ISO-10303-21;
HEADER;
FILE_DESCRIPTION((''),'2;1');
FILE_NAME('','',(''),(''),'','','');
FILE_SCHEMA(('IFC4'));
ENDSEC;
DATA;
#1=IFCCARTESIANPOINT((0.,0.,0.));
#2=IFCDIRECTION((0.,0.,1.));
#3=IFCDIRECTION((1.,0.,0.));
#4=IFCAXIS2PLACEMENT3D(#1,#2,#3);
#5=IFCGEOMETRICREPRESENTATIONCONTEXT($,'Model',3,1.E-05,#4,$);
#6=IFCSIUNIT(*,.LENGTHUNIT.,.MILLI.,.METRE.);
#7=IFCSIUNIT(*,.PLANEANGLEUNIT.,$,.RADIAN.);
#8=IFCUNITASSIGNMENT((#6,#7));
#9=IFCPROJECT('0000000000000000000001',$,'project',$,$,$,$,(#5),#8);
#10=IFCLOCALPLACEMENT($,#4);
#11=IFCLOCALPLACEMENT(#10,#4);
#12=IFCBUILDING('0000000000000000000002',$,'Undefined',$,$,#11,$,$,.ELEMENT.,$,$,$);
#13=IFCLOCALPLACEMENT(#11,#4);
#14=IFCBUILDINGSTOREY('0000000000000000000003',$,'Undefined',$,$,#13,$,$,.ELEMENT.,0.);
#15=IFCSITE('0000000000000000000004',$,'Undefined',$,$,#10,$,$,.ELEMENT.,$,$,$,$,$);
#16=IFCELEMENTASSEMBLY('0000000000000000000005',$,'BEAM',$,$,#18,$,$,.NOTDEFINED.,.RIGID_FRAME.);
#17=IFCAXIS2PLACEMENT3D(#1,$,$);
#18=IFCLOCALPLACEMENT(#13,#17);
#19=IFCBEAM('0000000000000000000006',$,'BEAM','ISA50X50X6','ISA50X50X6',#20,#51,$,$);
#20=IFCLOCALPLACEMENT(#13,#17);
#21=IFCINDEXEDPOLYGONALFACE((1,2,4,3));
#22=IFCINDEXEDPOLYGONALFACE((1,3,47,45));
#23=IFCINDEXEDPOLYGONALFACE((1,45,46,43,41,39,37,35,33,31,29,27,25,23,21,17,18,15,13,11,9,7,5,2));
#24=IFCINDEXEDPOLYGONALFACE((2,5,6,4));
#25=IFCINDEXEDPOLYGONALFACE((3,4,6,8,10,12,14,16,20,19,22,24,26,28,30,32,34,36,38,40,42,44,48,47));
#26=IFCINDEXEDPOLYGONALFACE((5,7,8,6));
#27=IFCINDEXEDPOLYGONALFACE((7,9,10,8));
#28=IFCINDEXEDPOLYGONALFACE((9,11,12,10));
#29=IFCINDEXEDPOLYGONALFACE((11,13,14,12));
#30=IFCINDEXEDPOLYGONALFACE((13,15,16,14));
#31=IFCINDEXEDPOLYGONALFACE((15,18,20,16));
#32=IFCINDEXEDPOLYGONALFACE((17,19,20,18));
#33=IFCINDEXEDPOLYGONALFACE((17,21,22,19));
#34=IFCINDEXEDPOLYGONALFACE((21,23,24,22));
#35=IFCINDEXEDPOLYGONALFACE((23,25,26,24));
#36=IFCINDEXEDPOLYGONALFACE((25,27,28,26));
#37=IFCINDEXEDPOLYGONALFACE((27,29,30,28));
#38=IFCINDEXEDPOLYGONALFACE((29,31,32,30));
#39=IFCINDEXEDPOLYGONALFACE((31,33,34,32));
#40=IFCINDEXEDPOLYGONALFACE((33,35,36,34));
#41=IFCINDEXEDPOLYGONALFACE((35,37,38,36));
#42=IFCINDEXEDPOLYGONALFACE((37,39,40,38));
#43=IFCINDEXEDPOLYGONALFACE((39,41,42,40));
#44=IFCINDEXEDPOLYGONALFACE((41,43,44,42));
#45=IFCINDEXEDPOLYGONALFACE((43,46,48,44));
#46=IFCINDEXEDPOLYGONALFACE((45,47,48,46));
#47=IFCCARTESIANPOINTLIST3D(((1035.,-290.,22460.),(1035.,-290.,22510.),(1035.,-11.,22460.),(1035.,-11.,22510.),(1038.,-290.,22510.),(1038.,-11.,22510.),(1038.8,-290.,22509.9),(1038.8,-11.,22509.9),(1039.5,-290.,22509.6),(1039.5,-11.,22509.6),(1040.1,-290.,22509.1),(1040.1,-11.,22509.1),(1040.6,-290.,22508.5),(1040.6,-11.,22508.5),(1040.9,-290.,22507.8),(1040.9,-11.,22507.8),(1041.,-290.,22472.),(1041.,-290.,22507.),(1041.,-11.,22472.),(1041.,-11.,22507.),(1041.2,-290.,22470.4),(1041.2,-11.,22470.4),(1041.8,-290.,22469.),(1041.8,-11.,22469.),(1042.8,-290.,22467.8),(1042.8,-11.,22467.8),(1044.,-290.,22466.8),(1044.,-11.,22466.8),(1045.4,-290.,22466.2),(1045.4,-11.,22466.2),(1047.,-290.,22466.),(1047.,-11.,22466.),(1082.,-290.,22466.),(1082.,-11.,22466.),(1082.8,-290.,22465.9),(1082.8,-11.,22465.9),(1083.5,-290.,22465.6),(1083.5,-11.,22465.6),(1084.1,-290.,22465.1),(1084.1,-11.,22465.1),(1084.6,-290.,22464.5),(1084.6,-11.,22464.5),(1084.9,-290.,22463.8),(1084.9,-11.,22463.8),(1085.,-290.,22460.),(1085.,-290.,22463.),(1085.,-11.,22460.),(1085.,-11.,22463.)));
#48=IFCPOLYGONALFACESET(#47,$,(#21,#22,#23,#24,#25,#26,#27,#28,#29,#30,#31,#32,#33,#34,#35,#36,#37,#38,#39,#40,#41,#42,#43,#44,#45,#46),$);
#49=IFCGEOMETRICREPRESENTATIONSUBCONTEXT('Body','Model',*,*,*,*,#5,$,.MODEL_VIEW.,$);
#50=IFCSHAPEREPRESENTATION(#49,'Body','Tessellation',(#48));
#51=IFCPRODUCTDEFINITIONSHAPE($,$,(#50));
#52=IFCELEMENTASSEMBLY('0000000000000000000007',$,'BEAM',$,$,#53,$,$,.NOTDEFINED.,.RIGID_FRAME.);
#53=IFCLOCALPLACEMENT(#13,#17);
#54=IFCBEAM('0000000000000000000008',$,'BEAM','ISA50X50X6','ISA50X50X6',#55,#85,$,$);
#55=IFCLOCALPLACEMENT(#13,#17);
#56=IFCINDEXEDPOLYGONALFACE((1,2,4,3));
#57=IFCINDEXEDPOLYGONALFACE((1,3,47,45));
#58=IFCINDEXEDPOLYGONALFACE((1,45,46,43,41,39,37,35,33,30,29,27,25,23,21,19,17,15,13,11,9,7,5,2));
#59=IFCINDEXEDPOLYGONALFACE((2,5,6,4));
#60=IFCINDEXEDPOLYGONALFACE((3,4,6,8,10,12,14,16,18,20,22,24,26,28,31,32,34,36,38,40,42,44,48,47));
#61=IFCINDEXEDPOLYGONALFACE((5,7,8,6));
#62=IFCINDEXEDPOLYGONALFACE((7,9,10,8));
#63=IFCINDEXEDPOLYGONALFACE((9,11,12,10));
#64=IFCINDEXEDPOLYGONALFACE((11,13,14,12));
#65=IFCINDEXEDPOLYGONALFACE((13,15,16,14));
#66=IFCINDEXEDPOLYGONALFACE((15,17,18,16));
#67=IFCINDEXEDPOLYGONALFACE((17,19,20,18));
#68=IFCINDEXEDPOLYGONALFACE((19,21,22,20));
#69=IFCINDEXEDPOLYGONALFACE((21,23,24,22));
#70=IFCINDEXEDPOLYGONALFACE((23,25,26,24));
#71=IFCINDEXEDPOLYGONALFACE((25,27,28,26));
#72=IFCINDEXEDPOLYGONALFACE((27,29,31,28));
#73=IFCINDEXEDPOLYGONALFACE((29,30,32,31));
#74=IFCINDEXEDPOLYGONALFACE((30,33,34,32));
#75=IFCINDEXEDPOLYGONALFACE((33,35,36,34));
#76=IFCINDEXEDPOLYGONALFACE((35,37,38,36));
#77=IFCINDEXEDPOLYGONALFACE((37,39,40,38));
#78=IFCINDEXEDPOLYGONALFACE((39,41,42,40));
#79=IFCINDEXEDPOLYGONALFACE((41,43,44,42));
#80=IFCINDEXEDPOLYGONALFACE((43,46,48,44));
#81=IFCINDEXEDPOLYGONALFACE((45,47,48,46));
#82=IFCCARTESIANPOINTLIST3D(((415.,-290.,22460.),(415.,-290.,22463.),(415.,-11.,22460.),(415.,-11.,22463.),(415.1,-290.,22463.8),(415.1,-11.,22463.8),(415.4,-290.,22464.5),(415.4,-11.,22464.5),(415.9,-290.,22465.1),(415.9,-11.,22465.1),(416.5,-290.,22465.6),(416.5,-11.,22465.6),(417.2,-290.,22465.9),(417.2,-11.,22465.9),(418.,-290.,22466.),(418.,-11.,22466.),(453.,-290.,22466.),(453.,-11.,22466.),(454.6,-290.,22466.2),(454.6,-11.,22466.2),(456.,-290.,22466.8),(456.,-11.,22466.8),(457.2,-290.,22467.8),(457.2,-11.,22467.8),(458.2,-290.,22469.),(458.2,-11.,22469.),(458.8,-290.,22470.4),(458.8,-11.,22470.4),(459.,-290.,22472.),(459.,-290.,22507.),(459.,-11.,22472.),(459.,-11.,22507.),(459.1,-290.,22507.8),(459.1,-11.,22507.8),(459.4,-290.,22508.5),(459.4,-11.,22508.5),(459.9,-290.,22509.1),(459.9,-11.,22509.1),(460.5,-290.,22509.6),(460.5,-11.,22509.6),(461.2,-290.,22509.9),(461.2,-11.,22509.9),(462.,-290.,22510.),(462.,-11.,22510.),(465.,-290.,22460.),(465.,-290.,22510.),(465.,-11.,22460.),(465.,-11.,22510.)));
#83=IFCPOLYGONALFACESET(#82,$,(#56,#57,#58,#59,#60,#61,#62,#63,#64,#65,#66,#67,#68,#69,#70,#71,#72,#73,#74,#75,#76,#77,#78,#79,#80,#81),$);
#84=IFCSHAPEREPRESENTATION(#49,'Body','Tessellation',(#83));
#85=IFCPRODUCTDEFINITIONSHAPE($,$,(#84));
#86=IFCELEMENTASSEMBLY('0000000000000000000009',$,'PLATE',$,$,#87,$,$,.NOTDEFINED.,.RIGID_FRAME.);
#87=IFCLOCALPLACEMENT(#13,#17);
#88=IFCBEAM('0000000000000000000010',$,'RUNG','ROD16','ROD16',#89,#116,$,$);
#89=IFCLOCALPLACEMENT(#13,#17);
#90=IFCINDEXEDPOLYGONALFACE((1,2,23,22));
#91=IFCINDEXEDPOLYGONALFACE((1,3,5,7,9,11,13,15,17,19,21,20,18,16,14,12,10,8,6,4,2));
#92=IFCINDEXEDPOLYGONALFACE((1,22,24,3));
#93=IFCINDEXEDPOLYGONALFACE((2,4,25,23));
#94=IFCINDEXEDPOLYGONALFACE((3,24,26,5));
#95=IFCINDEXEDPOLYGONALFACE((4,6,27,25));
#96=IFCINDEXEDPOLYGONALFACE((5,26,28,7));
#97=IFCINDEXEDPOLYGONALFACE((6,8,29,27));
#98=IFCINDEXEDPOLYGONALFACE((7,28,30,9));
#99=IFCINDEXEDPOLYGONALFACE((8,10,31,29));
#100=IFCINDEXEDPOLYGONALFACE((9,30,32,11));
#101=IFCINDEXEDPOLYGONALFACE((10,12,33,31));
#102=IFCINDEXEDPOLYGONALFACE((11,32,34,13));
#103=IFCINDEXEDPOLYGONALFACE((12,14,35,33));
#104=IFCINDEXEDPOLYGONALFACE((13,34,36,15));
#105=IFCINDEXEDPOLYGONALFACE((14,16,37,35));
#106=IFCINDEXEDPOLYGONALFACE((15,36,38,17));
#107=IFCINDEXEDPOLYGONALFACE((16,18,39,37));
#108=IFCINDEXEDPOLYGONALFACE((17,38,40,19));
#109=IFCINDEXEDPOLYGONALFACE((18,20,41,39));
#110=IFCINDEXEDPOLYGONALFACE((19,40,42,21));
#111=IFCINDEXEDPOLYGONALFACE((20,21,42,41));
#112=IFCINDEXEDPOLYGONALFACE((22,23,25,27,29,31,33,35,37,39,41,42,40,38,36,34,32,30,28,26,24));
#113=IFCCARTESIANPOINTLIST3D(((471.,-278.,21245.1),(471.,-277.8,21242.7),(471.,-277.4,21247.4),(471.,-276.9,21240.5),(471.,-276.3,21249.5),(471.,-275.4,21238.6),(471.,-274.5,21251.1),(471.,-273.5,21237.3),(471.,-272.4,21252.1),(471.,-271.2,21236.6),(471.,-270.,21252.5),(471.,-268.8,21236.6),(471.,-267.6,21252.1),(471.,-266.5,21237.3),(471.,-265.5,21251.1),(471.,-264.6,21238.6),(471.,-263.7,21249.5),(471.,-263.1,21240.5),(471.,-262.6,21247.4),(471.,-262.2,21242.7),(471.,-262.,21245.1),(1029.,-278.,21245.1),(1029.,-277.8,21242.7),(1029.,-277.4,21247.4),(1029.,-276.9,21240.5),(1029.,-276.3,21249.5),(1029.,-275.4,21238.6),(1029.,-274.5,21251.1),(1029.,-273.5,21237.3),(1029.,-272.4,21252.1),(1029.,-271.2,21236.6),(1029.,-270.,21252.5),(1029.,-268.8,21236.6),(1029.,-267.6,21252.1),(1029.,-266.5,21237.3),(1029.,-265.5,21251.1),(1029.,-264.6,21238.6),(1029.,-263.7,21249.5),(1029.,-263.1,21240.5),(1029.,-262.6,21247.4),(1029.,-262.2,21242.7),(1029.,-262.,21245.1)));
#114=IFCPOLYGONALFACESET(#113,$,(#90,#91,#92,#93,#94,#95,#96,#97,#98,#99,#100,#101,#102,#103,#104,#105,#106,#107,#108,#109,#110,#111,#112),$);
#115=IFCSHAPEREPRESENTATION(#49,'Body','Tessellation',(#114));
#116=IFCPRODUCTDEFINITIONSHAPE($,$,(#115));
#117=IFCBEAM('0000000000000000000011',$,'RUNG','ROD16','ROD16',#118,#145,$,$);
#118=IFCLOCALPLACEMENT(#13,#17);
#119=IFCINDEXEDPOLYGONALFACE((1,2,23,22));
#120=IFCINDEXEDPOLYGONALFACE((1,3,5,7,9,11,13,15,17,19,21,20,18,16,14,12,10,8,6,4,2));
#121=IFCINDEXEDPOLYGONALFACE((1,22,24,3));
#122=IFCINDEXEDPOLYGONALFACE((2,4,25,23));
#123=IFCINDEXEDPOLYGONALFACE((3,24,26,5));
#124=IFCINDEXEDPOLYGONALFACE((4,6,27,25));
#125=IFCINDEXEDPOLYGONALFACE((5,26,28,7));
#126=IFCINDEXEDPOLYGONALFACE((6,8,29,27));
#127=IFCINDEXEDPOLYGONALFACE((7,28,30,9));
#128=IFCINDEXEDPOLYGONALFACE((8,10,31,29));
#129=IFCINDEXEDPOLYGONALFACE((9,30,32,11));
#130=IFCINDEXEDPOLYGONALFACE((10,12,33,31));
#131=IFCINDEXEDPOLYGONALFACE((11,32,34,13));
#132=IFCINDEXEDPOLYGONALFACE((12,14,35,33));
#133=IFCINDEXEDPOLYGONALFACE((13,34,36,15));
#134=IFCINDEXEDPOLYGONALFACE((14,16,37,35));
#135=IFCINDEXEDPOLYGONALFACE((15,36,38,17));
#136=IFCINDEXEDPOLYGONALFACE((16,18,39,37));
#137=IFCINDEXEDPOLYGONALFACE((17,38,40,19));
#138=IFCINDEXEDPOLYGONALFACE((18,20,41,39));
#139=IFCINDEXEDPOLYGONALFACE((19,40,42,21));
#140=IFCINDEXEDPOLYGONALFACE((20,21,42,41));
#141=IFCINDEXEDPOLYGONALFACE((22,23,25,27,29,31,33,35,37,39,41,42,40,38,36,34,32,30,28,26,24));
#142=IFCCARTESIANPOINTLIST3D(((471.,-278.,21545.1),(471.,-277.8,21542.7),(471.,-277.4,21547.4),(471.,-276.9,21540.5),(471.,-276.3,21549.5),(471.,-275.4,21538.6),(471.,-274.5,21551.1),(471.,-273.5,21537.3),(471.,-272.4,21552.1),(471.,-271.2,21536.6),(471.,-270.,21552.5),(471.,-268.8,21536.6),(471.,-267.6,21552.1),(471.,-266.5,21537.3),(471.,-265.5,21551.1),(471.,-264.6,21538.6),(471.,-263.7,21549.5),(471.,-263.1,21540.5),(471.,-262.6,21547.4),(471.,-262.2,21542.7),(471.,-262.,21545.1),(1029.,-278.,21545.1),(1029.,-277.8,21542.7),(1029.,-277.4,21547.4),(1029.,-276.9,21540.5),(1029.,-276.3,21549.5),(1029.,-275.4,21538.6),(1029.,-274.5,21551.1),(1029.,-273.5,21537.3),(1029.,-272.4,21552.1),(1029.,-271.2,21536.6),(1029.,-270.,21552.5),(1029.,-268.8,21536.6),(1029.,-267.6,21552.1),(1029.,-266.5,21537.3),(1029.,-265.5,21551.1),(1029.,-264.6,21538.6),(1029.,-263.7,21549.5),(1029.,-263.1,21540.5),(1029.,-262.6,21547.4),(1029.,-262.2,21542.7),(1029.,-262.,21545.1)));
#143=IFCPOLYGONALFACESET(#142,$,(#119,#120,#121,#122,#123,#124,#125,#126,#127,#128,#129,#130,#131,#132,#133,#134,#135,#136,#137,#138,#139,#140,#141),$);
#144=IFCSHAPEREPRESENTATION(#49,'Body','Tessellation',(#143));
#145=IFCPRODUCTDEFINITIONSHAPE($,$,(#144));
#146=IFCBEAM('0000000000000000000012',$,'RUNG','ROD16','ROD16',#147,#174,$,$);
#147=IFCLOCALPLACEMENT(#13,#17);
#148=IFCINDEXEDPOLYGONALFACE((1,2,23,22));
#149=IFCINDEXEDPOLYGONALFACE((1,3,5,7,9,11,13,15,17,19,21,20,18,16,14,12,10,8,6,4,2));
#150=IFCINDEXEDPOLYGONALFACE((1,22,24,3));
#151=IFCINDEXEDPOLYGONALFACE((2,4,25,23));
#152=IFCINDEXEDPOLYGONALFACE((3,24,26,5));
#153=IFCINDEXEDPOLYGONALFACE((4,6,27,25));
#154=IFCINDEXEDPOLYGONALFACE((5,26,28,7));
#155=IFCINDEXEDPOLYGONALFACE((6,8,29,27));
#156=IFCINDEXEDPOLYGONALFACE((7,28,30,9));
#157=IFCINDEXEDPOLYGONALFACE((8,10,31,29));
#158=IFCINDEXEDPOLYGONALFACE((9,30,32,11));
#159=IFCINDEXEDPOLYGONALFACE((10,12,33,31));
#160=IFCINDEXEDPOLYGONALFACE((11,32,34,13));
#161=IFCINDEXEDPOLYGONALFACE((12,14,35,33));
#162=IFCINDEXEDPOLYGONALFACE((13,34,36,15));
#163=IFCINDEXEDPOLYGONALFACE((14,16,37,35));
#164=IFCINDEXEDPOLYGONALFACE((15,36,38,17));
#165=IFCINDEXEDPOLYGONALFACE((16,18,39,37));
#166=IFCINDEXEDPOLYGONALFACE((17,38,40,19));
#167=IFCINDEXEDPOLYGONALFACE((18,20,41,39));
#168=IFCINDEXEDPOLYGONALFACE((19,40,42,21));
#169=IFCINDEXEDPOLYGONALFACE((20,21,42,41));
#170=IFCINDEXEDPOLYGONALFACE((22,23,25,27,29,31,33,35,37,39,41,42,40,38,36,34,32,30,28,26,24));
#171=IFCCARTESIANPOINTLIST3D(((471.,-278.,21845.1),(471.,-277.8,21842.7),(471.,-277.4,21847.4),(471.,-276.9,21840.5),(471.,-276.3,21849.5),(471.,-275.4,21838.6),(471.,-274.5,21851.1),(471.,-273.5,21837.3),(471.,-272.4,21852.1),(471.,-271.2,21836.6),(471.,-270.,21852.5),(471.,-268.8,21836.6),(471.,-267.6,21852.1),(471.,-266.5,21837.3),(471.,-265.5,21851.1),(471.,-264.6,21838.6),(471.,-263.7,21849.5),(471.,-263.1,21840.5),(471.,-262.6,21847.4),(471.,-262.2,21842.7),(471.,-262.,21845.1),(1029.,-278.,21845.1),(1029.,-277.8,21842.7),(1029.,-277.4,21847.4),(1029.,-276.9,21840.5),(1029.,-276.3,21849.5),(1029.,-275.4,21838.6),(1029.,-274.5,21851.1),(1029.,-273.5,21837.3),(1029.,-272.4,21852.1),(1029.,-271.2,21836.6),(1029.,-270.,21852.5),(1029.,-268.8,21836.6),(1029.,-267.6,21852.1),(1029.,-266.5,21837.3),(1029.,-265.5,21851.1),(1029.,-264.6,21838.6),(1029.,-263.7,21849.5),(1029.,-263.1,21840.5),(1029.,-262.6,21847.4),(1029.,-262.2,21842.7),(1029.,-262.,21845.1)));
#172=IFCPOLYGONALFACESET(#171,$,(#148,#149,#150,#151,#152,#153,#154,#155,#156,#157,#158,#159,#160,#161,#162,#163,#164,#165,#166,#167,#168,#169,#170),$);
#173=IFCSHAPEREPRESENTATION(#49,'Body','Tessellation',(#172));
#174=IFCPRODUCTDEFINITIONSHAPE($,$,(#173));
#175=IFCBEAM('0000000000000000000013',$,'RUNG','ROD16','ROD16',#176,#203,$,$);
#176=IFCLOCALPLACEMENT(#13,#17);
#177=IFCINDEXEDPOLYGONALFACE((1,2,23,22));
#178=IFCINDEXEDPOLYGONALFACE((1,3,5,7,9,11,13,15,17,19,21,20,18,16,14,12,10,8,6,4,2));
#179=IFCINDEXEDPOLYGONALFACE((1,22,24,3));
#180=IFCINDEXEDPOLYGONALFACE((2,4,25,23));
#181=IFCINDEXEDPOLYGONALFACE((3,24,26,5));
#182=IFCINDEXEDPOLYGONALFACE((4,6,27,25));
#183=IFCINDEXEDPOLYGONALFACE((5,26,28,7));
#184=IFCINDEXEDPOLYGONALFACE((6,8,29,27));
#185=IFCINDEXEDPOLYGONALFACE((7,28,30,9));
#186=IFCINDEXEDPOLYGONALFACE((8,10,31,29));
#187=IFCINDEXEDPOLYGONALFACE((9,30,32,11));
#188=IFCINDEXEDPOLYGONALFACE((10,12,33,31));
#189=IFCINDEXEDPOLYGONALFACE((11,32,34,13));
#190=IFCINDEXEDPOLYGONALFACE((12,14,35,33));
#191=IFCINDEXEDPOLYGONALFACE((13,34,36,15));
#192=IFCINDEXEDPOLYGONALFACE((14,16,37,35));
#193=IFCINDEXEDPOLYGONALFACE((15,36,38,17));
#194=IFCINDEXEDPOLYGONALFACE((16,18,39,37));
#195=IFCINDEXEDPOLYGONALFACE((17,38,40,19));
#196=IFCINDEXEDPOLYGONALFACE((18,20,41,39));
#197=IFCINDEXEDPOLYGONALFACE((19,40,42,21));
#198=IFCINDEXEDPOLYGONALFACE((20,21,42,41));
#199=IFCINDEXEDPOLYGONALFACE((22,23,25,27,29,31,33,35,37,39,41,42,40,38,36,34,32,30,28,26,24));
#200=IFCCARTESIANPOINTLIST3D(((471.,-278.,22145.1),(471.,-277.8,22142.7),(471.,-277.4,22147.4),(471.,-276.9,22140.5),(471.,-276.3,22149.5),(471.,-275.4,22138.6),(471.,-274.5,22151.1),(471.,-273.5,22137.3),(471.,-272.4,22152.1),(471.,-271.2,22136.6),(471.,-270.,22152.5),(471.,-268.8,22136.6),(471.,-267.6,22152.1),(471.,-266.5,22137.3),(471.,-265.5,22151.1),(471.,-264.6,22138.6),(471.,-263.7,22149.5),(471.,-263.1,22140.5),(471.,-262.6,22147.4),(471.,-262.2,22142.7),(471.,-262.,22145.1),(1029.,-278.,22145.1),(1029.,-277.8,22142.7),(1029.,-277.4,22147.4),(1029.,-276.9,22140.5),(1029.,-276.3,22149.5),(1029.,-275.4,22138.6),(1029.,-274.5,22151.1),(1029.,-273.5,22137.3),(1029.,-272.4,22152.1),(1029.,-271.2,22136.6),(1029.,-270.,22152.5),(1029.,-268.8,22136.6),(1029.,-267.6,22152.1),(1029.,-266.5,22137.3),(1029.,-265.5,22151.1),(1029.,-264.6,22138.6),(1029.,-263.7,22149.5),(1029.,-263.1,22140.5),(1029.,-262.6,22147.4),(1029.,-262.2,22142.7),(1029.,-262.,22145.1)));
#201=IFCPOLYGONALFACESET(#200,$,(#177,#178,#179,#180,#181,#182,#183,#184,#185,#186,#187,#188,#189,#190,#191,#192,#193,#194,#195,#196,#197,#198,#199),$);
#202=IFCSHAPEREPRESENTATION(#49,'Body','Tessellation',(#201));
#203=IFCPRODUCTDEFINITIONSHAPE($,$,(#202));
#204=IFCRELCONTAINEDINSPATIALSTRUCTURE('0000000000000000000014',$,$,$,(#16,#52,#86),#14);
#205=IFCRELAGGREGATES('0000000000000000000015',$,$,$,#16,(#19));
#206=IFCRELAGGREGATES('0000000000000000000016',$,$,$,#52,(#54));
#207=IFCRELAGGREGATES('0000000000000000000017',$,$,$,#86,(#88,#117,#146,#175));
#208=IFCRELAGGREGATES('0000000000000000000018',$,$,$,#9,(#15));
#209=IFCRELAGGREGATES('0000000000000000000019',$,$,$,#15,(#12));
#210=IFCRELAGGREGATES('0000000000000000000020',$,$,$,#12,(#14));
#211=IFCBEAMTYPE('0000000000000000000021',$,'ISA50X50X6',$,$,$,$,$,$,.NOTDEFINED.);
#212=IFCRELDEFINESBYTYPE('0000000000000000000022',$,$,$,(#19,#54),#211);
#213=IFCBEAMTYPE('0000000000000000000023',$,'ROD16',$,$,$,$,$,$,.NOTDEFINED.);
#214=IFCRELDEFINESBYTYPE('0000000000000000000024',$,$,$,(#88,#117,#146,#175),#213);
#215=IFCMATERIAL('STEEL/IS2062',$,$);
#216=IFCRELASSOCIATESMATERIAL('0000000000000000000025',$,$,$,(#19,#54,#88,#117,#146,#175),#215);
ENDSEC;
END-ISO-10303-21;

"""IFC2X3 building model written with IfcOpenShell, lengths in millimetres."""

from ifc_helpers import new_model, si_unit, frame, origin_with_axes, origin_2d_with_axis, place, context, subcontext, project, spatial, circle, l_section, extrude, material, type_object, element, aggregate, save


model = new_model("IFC2X3")

# Units and contexts
model_context = context("Model", 3, precision=1e-05, world=origin_with_axes())
body_context = subcontext(model_context, "Body", "Model", "MODEL_VIEW")
ifc_project = project(units=[si_unit("LENGTHUNIT", "METRE", prefix="MILLI"), si_unit("PLANEANGLEUNIT", "RADIAN")], contexts=[model_context])

# Site, building, storey
site_placement = place(None, origin_with_axes())
site = spatial("IfcSite", under=ifc_project, at=site_placement, Name="Undefined", CompositionType="ELEMENT")
building_placement = place(site_placement, origin_with_axes())
building = spatial("IfcBuilding", under=site, at=building_placement, Name="Undefined", CompositionType="ELEMENT")
storey_placement = place(building_placement, origin_with_axes())
storey = spatial("IfcBuildingStorey", under=building, at=storey_placement, Name="Undefined", CompositionType="ELEMENT", Elevation=0.0)

# Element assemblies, beams
assembly_1_placement = place(storey_placement, origin_with_axes())
assembly_1 = element("IfcElementAssembly", 1, at=assembly_1_placement, inside=storey, Name="BEAM", AssemblyPlace="NOTDEFINED", PredefinedType="RIGID_FRAME")
ifc_material = material(Name="STEEL/IS2062")
beam_type_1 = type_object("IfcBeamType", Name="ISA50X50X6", PredefinedType="NOTDEFINED")
beam_1_placement = place(assembly_1_placement, frame((1060.0, -290.0, 22485.0), z_axis=(0.0, 0.0, 1.0), x_axis=(0.0, 1.0, 0.0)))
beam_1 = element("IfcBeam", 2, at=beam_1_placement, type_object=beam_type_1, material=ifc_material, Name="BEAM", Description="ISA50X50X6", ObjectType="ISA50X50X6", context=body_context, shape_type="SweptSolid", body=[
    extrude(l_section(Depth=50.0, Width=50.0, Thickness=6.0, FilletRadius=6.0, EdgeRadius=3.0, at=origin_2d_with_axis()), frame((279.0, 0.0, 0.0), z_axis=(-1.0, 0.0, 0.0), x_axis=(0.0, -1.0, 0.0)), (0.0, 0.0, 1.0), 279.0),
])
aggregate(assembly_1, [beam_1])
assembly_2_placement = place(storey_placement, origin_with_axes())
assembly_2 = element("IfcElementAssembly", 3, at=assembly_2_placement, inside=storey, Name="BEAM", AssemblyPlace="NOTDEFINED", PredefinedType="RIGID_FRAME")
beam_2_placement = place(assembly_2_placement, frame((440.0, -11.0, 22485.0), z_axis=(0.0, 0.0, 1.0), x_axis=(0.0, -1.0, 0.0)))
beam_2 = element("IfcBeam", 4, at=beam_2_placement, type_object=beam_type_1, material=ifc_material, Name="BEAM", Description="ISA50X50X6", ObjectType="ISA50X50X6", context=body_context, shape_type="SweptSolid", body=[
    extrude(l_section(Depth=50.0, Width=50.0, Thickness=6.0, FilletRadius=6.0, EdgeRadius=3.0, at=origin_2d_with_axis()), frame((279.0, 0.0, 0.0), z_axis=(-1.0, 0.0, 0.0), x_axis=(0.0, -1.0, 0.0)), (0.0, 0.0, 1.0), 279.0),
])
aggregate(assembly_2, [beam_2])

# Element assembly, beams
assembly_3_placement = place(storey_placement, origin_with_axes())
assembly_3 = element("IfcElementAssembly", 5, at=assembly_3_placement, inside=storey, Name="PLATE", AssemblyPlace="NOTDEFINED", PredefinedType="RIGID_FRAME")
beam_type_2 = type_object("IfcBeamType", Name="ROD16", PredefinedType="NOTDEFINED")
beam_3_placement = place(assembly_3_placement, frame((471.0, -270.0, 21244.5), z_axis=(0.0, 1.0, 0.0), x_axis=(1.0, 0.0, 0.0)))
beam_3 = element("IfcBeam", 6, at=beam_3_placement, type_object=beam_type_2, material=ifc_material, Name="RUNG", Description="ROD16", ObjectType="ROD16", context=body_context, shape_type="SweptSolid", body=[
    extrude(circle(Radius=8.0, at=origin_2d_with_axis()), frame((558.0, 0.0, 0.0), z_axis=(-1.0, 0.0, 0.0), x_axis=(0.0, -1.0, 0.0)), (0.0, 0.0, 1.0), 558.0),
])
beam_4_placement = place(assembly_3_placement, frame((471.0, -270.0, 21544.5), z_axis=(0.0, 1.0, 0.0), x_axis=(1.0, 0.0, 0.0)))
beam_4 = element("IfcBeam", 7, at=beam_4_placement, type_object=beam_type_2, material=ifc_material, Name="RUNG", Description="ROD16", ObjectType="ROD16", context=body_context, shape_type="SweptSolid", body=[
    extrude(circle(Radius=8.0, at=origin_2d_with_axis()), frame((558.0, 0.0, 0.0), z_axis=(-1.0, 0.0, 0.0), x_axis=(0.0, -1.0, 0.0)), (0.0, 0.0, 1.0), 558.0),
])
beam_5_placement = place(assembly_3_placement, frame((471.0, -270.0, 21844.5), z_axis=(0.0, 1.0, 0.0), x_axis=(1.0, 0.0, 0.0)))
beam_5 = element("IfcBeam", 8, at=beam_5_placement, type_object=beam_type_2, material=ifc_material, Name="RUNG", Description="ROD16", ObjectType="ROD16", context=body_context, shape_type="SweptSolid", body=[
    extrude(circle(Radius=8.0, at=origin_2d_with_axis()), frame((558.0, 0.0, 0.0), z_axis=(-1.0, 0.0, 0.0), x_axis=(0.0, -1.0, 0.0)), (0.0, 0.0, 1.0), 558.0),
])
beam_6_placement = place(assembly_3_placement, frame((471.0, -270.0, 22144.5), z_axis=(0.0, 1.0, 0.0), x_axis=(1.0, 0.0, 0.0)))
beam_6 = element("IfcBeam", 9, at=beam_6_placement, type_object=beam_type_2, material=ifc_material, Name="RUNG", Description="ROD16", ObjectType="ROD16", context=body_context, shape_type="SweptSolid", body=[
    extrude(circle(Radius=8.0, at=origin_2d_with_axis()), frame((558.0, 0.0, 0.0), z_axis=(-1.0, 0.0, 0.0), x_axis=(0.0, -1.0, 0.0)), (0.0, 0.0, 1.0), 558.0),
])
aggregate(assembly_3, [beam_3, beam_4, beam_5, beam_6])

save(model, "model.ifc")
